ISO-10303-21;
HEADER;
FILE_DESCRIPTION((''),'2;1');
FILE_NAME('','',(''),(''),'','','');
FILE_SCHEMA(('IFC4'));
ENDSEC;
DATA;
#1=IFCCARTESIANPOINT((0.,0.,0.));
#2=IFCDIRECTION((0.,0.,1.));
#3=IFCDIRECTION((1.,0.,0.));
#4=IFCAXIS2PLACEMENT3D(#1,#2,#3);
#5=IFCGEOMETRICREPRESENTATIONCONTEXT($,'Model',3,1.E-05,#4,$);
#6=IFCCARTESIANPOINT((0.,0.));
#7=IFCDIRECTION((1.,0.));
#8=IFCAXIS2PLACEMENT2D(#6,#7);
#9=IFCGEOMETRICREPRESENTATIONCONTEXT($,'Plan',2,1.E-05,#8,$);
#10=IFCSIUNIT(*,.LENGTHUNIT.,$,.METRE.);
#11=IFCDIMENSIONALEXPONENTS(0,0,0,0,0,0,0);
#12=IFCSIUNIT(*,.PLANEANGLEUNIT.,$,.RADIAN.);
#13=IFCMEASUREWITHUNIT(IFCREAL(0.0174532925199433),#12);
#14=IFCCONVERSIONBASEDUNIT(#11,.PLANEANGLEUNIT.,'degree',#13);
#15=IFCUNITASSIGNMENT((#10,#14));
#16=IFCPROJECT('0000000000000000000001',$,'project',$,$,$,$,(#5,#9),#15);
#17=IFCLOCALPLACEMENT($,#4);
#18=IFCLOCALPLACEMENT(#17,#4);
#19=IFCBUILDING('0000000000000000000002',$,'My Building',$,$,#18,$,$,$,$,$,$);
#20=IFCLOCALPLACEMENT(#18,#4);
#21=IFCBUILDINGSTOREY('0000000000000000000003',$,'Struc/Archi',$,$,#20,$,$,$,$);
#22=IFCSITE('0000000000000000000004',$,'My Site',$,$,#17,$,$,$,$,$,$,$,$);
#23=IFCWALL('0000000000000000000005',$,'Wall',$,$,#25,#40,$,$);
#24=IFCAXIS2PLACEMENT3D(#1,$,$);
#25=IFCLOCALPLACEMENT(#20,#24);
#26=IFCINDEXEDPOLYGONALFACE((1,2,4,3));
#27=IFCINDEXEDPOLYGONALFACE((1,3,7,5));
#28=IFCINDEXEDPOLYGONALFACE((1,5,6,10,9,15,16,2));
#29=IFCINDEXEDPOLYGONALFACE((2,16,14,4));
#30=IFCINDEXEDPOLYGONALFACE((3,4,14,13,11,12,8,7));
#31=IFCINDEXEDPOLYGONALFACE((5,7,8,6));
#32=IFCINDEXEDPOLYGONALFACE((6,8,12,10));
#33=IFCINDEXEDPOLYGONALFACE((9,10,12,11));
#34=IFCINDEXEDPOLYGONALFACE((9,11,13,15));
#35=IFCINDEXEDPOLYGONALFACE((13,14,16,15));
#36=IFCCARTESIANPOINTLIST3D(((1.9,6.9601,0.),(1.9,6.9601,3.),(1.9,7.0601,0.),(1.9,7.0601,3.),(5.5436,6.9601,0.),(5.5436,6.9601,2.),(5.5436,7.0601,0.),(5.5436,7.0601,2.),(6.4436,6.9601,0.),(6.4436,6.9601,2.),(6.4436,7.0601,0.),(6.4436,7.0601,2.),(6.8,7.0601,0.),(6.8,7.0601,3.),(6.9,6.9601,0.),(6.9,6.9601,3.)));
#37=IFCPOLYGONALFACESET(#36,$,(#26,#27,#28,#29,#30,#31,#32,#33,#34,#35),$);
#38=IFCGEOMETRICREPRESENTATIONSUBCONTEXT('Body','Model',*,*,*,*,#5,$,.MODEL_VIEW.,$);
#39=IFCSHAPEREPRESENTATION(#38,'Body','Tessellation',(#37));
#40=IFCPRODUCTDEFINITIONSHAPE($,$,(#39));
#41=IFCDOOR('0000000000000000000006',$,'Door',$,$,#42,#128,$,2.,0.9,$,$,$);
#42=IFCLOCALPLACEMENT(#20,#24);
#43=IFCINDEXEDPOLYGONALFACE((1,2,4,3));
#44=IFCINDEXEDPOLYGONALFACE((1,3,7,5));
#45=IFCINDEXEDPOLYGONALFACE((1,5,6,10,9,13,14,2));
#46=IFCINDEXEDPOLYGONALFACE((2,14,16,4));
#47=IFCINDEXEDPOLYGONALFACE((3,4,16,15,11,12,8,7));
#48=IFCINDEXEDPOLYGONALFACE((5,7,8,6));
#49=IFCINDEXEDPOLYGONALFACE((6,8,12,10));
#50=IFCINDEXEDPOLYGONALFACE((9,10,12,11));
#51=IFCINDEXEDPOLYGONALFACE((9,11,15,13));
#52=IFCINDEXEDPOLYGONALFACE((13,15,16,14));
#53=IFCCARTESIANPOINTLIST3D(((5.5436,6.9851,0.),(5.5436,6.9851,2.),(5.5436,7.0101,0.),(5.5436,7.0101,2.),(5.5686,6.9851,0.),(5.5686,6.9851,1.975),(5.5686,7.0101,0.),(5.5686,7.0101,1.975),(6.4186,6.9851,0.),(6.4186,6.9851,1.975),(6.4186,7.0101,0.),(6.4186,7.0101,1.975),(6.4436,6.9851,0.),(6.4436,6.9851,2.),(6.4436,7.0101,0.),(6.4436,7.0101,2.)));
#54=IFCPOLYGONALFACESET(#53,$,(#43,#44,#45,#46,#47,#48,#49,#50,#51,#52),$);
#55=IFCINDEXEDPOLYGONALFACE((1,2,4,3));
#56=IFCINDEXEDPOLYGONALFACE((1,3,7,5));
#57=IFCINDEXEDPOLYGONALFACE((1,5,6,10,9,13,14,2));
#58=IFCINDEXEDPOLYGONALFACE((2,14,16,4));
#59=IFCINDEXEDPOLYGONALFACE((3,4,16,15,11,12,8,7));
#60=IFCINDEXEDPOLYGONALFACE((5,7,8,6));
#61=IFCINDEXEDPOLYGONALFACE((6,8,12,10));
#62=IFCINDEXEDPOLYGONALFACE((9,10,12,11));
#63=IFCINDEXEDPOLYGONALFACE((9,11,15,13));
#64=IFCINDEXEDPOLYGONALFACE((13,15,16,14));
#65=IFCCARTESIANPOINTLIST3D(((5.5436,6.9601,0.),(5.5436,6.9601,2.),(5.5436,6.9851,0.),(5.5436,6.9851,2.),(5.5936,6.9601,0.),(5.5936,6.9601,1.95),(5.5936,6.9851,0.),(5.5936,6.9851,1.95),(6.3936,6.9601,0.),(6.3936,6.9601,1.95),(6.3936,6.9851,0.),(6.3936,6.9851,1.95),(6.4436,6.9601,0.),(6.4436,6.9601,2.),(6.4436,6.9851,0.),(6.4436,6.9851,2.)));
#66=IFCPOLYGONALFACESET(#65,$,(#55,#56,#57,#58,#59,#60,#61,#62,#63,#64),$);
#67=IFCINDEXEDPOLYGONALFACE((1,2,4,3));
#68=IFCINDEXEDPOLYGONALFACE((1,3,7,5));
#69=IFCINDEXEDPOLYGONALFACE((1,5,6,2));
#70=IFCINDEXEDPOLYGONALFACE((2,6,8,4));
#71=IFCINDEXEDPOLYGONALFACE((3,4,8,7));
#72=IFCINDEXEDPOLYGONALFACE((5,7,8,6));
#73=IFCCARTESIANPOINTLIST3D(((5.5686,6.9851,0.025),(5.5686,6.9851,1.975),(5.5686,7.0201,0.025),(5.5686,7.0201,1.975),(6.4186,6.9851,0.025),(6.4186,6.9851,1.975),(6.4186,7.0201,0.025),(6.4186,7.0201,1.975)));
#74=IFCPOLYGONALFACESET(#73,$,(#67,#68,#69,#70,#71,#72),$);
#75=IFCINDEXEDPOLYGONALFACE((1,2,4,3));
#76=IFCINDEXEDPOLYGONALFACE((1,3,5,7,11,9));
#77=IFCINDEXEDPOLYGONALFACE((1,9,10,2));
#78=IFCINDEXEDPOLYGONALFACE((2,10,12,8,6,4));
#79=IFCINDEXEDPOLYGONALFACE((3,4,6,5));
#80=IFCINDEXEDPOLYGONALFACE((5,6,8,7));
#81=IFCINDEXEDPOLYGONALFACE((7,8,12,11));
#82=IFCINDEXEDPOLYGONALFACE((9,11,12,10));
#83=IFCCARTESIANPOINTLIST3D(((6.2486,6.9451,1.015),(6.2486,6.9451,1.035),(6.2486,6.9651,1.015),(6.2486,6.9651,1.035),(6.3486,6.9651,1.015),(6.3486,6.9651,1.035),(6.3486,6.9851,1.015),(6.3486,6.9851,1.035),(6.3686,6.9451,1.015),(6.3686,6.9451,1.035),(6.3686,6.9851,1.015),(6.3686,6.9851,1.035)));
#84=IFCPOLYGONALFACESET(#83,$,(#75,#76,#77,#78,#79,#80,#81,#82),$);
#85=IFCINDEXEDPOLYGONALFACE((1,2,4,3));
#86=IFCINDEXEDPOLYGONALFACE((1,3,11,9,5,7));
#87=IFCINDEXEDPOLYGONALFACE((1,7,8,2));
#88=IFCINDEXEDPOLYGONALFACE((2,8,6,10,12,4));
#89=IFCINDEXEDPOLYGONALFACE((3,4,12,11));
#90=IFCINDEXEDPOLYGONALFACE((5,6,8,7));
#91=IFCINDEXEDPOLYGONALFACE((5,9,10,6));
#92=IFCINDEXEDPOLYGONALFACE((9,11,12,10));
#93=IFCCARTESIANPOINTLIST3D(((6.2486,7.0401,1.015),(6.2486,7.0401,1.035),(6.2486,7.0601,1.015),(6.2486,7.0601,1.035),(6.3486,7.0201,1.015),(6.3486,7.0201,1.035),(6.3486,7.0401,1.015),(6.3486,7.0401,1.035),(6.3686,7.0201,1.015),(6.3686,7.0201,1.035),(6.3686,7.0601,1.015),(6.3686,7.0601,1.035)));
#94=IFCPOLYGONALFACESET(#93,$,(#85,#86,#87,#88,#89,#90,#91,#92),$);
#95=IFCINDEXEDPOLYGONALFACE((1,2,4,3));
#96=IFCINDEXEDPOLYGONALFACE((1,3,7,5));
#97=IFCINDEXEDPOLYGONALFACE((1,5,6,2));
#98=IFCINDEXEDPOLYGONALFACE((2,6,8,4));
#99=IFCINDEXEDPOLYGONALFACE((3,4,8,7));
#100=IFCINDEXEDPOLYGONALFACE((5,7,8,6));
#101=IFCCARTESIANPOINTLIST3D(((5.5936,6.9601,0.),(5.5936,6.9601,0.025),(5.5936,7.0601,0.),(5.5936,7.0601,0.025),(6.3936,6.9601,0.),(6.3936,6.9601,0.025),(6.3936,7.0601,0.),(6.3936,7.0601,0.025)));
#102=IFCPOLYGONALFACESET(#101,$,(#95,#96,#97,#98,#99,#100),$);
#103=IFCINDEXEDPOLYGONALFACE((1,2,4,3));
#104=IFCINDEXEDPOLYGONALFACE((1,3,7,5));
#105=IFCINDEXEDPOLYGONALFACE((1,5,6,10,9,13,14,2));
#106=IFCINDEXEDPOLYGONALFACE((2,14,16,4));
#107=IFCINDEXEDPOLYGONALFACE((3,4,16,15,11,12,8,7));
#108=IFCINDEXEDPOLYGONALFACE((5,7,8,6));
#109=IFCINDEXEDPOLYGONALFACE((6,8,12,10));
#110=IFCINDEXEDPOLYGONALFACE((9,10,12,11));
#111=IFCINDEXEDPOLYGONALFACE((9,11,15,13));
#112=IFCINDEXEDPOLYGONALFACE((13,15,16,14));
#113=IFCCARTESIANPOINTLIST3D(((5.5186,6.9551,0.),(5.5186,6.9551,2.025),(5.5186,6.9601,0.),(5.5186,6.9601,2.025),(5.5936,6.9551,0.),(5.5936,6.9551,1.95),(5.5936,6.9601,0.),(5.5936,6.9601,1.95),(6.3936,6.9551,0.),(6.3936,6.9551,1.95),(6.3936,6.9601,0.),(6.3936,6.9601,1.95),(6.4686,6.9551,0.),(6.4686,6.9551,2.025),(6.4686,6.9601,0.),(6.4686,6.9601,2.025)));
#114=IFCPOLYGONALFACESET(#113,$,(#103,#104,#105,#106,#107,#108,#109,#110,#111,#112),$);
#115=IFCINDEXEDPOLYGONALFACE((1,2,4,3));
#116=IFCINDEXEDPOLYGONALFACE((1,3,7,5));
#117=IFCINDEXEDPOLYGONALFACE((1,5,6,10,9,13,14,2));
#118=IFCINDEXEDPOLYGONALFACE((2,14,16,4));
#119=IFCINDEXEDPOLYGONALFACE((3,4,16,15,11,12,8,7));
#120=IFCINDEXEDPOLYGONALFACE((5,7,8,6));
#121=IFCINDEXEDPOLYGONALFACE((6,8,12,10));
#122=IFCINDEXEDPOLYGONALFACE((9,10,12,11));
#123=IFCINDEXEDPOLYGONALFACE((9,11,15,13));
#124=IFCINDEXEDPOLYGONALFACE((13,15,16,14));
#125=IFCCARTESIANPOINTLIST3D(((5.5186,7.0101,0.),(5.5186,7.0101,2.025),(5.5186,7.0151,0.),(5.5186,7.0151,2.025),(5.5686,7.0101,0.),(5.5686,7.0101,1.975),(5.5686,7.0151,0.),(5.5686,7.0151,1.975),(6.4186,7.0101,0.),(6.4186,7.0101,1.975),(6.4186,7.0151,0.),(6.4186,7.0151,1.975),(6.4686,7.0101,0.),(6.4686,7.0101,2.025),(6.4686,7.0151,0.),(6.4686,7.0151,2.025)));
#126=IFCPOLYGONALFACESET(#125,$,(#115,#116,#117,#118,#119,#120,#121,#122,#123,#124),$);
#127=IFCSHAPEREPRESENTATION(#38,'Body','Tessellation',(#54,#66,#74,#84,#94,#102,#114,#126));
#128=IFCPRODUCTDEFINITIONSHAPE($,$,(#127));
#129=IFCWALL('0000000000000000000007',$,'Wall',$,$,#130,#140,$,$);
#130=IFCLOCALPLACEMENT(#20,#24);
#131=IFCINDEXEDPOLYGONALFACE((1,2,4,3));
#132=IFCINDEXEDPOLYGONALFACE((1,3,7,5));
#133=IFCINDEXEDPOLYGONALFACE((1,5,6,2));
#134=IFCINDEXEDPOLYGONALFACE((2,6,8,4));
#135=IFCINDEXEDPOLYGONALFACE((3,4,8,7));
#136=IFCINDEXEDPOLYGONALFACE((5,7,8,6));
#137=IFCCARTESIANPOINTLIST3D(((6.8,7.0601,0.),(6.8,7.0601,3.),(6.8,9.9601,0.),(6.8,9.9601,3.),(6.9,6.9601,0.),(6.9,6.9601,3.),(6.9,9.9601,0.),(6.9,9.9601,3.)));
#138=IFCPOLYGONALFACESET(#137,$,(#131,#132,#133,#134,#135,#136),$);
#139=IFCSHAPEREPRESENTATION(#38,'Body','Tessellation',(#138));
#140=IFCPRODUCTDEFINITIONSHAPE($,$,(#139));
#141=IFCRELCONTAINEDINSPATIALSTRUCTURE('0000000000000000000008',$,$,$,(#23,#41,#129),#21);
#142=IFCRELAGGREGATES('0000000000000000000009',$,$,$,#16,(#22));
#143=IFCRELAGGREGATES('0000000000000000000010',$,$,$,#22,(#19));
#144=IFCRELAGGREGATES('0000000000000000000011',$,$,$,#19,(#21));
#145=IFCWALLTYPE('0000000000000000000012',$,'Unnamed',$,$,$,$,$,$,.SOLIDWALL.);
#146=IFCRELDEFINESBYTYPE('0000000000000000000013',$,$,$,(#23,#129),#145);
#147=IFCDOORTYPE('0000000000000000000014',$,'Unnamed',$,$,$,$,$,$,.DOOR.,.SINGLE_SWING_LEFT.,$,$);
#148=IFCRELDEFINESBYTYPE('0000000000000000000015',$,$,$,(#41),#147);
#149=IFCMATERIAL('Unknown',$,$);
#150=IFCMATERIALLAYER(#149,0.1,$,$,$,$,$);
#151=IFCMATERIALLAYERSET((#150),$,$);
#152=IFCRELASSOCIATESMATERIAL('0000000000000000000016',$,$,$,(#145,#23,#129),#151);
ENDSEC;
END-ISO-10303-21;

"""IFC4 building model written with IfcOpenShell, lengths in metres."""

from ifc_helpers import new_model, entity, si_unit, converted_unit, frame, origin_with_axes, origin_2d_with_axis, place, context, subcontext, project, spatial, line, indexed_curve, outline, extrude, shape, source, transform, mapped, material, layer, layer_set, layer_usage, type_object, type_shapes, element, fill, save


model = new_model("IFC4")

# Units and contexts
model_context = context("Model", 3, precision=1e-05, world=origin_with_axes())
plan_context = context("Plan", 2, precision=1e-05, world=origin_2d_with_axis())
body_context_1 = subcontext(model_context, "Body", "Model", "MODEL_VIEW")
body_context_2 = subcontext(plan_context, "Body", "Plan", "PLAN_VIEW")
ifc_project = project(units=[si_unit("LENGTHUNIT", "METRE"), converted_unit("PLANEANGLEUNIT", "degree", entity("IfcReal", 0.0174532925199433), si_unit("PLANEANGLEUNIT", "RADIAN"), dimensions=[0, 0, 0, 0, 0, 0, 0])], contexts=[model_context, plan_context])

# Site, building, storey
site_placement = place(None, origin_with_axes())
site = spatial("IfcSite", under=ifc_project, at=site_placement, Name="My Site")
building_placement = place(site_placement, origin_with_axes())
building = spatial("IfcBuilding", under=site, at=building_placement, Name="My Building")
storey_placement = place(building_placement, origin_with_axes())
storey = spatial("IfcBuildingStorey", under=building, at=storey_placement, Name="Struc/Archi")

# Shared definitions
ifc_material = material(Name="Unknown")

# Shared definitions
ifc_layer_1 = layer(ifc_material, 0.1)
ifc_layer_set_1 = layer_set([ifc_layer_1])
wall_type = type_object("IfcWallType", Name="Unnamed", PredefinedType="SOLIDWALL", material=ifc_layer_set_1)

# Wall, opening, door
ifc_layer_usage_1 = layer_usage(ifc_layer_set_1, "AXIS2", "POSITIVE", 0.0)
wall_1_placement = place(storey_placement, frame((1.9, 6.9601, 0.0), z_axis=(0.0, 0.0, 1.0), x_axis=(1.0, 0.0, 0.0)))
wall_1 = element("IfcWall", 1, at=wall_1_placement, inside=storey, type_object=wall_type, material=ifc_layer_usage_1, Name="Wall", context=body_context_1, shape_type="SweptSolid", body=[
    extrude(outline(indexed_curve([(0.0, 0.0), (0.0, 0.1), (4.9, 0.1), (5.0, 0.0)], segments=[line(1, 2, 3, 4, 1)])), origin_with_axes(), (0.0, 0.0, 1.0), 3.0),
])
shared_shape_1 = source(origin_with_axes(), body_context_1, "Body", "SweptSolid", [
    extrude(outline(indexed_curve([(0.0, 0.0), (0.9, 0.0), (0.9, 2.0), (0.0, 2.0)], segments=[line(1, 2, 3, 4, 1)])), frame((0.0, -0.6, 0.0), z_axis=(0.0, -1.0, 0.0), x_axis=(1.0, 0.0, 0.0)), (0.0, 0.0, -1.0), 1.2),
])
opening_1_placement = place(wall_1_placement, frame((3.6436, 0.0, 0.0), z_axis=(0.0, 0.0, 1.0), x_axis=(1.0, 0.0, 0.0)))
opening_1 = element("IfcOpeningElement", 2, at=opening_1_placement, cuts=wall_1, PredefinedType="OPENING", context=body_context_1, shape_type="MappedRepresentation", body=[
    mapped(shared_shape_1, transform((0.0, 0.0, 0.0), x_axis=(1.0, 0.0, 0.0), y_axis=(0.0, 1.0, 0.0), z_axis=(0.0, 0.0, 1.0), scale=1.0)),
])
door_type = type_object("IfcDoorType", Name="Unnamed", OperationType="SINGLE_SWING_LEFT", PredefinedType="DOOR")
shared_shape_2 = source(origin_with_axes(), body_context_1, "Body", "SweptSolid", [
    extrude(outline(indexed_curve([(0.0, 0.0), (0.0, 2.0), (0.9, 2.0), (0.9, 0.0), (0.875, 0.0), (0.875, 1.975), (0.025, 1.975), (0.025, 0.0)], segments=[line(1, 2, 3, 4, 5, 6, 7, 8, 1)])), frame((0.0, 0.025, 0.0), z_axis=(0.0, -1.0, 0.0), x_axis=(1.0, 0.0, 0.0)), (0.0, 0.0, -1.0), 0.025),
    extrude(outline(indexed_curve([(0.0, 0.0), (0.0, 2.0), (0.9, 2.0), (0.9, 0.0), (0.85, 0.0), (0.85, 1.95), (0.05, 1.95), (0.05, 0.0)], segments=[line(1, 2, 3, 4, 5, 6, 7, 8, 1)])), frame((0.0, 0.0, 0.0), z_axis=(0.0, -1.0, 0.0), x_axis=(1.0, 0.0, 0.0)), (0.0, 0.0, -1.0), 0.025),
    extrude(outline(indexed_curve([(0.0, 0.0), (0.85, 0.0), (0.85, 0.035), (0.0, 0.035)], segments=[line(1, 2, 3, 4, 1)])), frame((0.025, 0.025, 0.025), z_axis=(0.0, 0.0, 1.0), x_axis=(1.0, 0.0, 0.0)), (0.0, 0.0, 1.0), 1.95),
    extrude(outline(indexed_curve([(0.0, 0.0), (0.0, -0.04), (-0.12, -0.04), (-0.12, -0.02), (-0.02, -0.02), (-0.02, 0.0)], segments=[line(1, 2, 3, 4, 5, 6, 1)])), frame((0.825, 0.025, 1.015), z_axis=(0.0, 0.0, 1.0), x_axis=(1.0, 0.0, 0.0)), (0.0, 0.0, 1.0), 0.02),
    extrude(outline(indexed_curve([(0.0, 0.0), (0.0, 0.04), (-0.12, 0.04), (-0.12, 0.02), (-0.02, 0.02), (-0.02, 0.0)], segments=[line(1, 2, 3, 4, 5, 6, 1)])), frame((0.825, 0.06, 1.015), z_axis=(0.0, 0.0, 1.0), x_axis=(1.0, 0.0, 0.0)), (0.0, 0.0, 1.0), 0.02),
    extrude(outline(indexed_curve([(0.0, 0.0), (0.8, 0.0), (0.8, 0.1), (0.0, 0.1)], segments=[line(1, 2, 3, 4, 1)])), frame((0.05, 0.0, 0.0), z_axis=(0.0, 0.0, 1.0), x_axis=(1.0, 0.0, 0.0)), (0.0, 0.0, 1.0), 0.025),
    extrude(outline(indexed_curve([(0.0, 0.0), (0.0, 2.025), (0.95, 2.025), (0.95, 0.0), (0.875, 0.0), (0.875, 1.95), (0.075, 1.95), (0.075, 0.0)], segments=[line(1, 2, 3, 4, 5, 6, 7, 8, 1)])), frame((-0.025, -0.005, 0.0), z_axis=(0.0, -1.0, 0.0), x_axis=(1.0, 0.0, 0.0)), (0.0, 0.0, -1.0), 0.005),
    extrude(outline(indexed_curve([(0.0, 0.0), (0.0, 2.025), (0.95, 2.025), (0.95, 0.0), (0.9, 0.0), (0.9, 1.975), (0.05, 1.975), (0.05, 0.0)], segments=[line(1, 2, 3, 4, 5, 6, 7, 8, 1)])), frame((-0.025, 0.05, 0.0), z_axis=(0.0, -1.0, 0.0), x_axis=(1.0, 0.0, 0.0)), (0.0, 0.0, -1.0), 0.005),
])
shared_shape_3 = source(origin_with_axes(), body_context_2, "Body", "Curve2D", [
    entity("IfcIndexedPolyCurve", entity("IfcCartesianPointList2D", [[0.0, 0.0], [0.0, 0.05], [0.025, 0.05], [0.025, 0.025], [0.05, 0.025], [0.05, 0.0]]), [entity("IfcLineIndex", [1, 2, 3, 4, 5, 6, 1])]),
    entity("IfcIndexedPolyCurve", entity("IfcCartesianPointList2D", [[0.9, 0.0], [0.9, 0.05], [0.875, 0.05], [0.875, 0.025], [0.85, 0.025], [0.85, 0.0]]), [entity("IfcLineIndex", [1, 2, 3, 4, 5, 6, 1])]),
    entity("IfcTrimmedCurve", entity("IfcEllipse", entity("IfcAxis2Placement2D", entity("IfcCartesianPoint", [0.06, 0.05]), entity("IfcDirection", [1.0, 0.0])), 0.815, 0.85), [entity("IfcCartesianPoint", [0.875, 0.05])], [entity("IfcCartesianPoint", [0.06, 0.9])], True, "CARTESIAN"),
    entity("IfcIndexedPolyCurve", entity("IfcCartesianPointList2D", [[0.025, 0.05], [0.06, 0.05], [0.06, 0.9], [0.025, 0.9]]), [entity("IfcLineIndex", [1, 2, 3, 4, 1])]),
])
type_shapes(door_type, [shared_shape_2, shared_shape_3])
door_1_placement = place(opening_1_placement, origin_with_axes())
door_1 = element("IfcDoor", 3, at=door_1_placement, inside=storey, type_object=door_type, Name="Door", OverallHeight=2.0, OverallWidth=0.9, shapes=[
    shape(body_context_1, "Body", "MappedRepresentation", [mapped(shared_shape_2, transform((0.0, 0.0, 0.0), x_axis=(1.0, 0.0, 0.0), y_axis=(0.0, 1.0, 0.0), z_axis=(0.0, 0.0, 1.0), scale=1.0))]),
    shape(body_context_2, "Body", "MappedRepresentation", [mapped(shared_shape_3, transform((0.0, 0.0, 0.0), x_axis=(1.0, 0.0, 0.0), y_axis=(0.0, 1.0, 0.0), z_axis=(0.0, 0.0, 1.0), scale=1.0))]),
])
fill(opening_1, door_1)

# Wall
ifc_layer_usage_2 = layer_usage(ifc_layer_set_1, "AXIS2", "POSITIVE", 0.0)
wall_2_placement = place(storey_placement, frame((6.9, 6.9601, 0.0), z_axis=(0.0, 0.0, 1.0), x_axis=(0.0, 1.0, 0.0)))
element("IfcWall", 4, at=wall_2_placement, inside=storey, type_object=wall_type, material=ifc_layer_usage_2, Name="Wall", context=body_context_1, shape_type="SweptSolid", body=[
    extrude(outline(indexed_curve([(0.0, 0.0), (0.1, 0.1), (3.0, 0.1), (3.0, 0.0)], segments=[line(1, 2, 3, 4, 1)])), origin_with_axes(), (0.0, 0.0, 1.0), 3.0),
])

save(model, "model.ifc")
